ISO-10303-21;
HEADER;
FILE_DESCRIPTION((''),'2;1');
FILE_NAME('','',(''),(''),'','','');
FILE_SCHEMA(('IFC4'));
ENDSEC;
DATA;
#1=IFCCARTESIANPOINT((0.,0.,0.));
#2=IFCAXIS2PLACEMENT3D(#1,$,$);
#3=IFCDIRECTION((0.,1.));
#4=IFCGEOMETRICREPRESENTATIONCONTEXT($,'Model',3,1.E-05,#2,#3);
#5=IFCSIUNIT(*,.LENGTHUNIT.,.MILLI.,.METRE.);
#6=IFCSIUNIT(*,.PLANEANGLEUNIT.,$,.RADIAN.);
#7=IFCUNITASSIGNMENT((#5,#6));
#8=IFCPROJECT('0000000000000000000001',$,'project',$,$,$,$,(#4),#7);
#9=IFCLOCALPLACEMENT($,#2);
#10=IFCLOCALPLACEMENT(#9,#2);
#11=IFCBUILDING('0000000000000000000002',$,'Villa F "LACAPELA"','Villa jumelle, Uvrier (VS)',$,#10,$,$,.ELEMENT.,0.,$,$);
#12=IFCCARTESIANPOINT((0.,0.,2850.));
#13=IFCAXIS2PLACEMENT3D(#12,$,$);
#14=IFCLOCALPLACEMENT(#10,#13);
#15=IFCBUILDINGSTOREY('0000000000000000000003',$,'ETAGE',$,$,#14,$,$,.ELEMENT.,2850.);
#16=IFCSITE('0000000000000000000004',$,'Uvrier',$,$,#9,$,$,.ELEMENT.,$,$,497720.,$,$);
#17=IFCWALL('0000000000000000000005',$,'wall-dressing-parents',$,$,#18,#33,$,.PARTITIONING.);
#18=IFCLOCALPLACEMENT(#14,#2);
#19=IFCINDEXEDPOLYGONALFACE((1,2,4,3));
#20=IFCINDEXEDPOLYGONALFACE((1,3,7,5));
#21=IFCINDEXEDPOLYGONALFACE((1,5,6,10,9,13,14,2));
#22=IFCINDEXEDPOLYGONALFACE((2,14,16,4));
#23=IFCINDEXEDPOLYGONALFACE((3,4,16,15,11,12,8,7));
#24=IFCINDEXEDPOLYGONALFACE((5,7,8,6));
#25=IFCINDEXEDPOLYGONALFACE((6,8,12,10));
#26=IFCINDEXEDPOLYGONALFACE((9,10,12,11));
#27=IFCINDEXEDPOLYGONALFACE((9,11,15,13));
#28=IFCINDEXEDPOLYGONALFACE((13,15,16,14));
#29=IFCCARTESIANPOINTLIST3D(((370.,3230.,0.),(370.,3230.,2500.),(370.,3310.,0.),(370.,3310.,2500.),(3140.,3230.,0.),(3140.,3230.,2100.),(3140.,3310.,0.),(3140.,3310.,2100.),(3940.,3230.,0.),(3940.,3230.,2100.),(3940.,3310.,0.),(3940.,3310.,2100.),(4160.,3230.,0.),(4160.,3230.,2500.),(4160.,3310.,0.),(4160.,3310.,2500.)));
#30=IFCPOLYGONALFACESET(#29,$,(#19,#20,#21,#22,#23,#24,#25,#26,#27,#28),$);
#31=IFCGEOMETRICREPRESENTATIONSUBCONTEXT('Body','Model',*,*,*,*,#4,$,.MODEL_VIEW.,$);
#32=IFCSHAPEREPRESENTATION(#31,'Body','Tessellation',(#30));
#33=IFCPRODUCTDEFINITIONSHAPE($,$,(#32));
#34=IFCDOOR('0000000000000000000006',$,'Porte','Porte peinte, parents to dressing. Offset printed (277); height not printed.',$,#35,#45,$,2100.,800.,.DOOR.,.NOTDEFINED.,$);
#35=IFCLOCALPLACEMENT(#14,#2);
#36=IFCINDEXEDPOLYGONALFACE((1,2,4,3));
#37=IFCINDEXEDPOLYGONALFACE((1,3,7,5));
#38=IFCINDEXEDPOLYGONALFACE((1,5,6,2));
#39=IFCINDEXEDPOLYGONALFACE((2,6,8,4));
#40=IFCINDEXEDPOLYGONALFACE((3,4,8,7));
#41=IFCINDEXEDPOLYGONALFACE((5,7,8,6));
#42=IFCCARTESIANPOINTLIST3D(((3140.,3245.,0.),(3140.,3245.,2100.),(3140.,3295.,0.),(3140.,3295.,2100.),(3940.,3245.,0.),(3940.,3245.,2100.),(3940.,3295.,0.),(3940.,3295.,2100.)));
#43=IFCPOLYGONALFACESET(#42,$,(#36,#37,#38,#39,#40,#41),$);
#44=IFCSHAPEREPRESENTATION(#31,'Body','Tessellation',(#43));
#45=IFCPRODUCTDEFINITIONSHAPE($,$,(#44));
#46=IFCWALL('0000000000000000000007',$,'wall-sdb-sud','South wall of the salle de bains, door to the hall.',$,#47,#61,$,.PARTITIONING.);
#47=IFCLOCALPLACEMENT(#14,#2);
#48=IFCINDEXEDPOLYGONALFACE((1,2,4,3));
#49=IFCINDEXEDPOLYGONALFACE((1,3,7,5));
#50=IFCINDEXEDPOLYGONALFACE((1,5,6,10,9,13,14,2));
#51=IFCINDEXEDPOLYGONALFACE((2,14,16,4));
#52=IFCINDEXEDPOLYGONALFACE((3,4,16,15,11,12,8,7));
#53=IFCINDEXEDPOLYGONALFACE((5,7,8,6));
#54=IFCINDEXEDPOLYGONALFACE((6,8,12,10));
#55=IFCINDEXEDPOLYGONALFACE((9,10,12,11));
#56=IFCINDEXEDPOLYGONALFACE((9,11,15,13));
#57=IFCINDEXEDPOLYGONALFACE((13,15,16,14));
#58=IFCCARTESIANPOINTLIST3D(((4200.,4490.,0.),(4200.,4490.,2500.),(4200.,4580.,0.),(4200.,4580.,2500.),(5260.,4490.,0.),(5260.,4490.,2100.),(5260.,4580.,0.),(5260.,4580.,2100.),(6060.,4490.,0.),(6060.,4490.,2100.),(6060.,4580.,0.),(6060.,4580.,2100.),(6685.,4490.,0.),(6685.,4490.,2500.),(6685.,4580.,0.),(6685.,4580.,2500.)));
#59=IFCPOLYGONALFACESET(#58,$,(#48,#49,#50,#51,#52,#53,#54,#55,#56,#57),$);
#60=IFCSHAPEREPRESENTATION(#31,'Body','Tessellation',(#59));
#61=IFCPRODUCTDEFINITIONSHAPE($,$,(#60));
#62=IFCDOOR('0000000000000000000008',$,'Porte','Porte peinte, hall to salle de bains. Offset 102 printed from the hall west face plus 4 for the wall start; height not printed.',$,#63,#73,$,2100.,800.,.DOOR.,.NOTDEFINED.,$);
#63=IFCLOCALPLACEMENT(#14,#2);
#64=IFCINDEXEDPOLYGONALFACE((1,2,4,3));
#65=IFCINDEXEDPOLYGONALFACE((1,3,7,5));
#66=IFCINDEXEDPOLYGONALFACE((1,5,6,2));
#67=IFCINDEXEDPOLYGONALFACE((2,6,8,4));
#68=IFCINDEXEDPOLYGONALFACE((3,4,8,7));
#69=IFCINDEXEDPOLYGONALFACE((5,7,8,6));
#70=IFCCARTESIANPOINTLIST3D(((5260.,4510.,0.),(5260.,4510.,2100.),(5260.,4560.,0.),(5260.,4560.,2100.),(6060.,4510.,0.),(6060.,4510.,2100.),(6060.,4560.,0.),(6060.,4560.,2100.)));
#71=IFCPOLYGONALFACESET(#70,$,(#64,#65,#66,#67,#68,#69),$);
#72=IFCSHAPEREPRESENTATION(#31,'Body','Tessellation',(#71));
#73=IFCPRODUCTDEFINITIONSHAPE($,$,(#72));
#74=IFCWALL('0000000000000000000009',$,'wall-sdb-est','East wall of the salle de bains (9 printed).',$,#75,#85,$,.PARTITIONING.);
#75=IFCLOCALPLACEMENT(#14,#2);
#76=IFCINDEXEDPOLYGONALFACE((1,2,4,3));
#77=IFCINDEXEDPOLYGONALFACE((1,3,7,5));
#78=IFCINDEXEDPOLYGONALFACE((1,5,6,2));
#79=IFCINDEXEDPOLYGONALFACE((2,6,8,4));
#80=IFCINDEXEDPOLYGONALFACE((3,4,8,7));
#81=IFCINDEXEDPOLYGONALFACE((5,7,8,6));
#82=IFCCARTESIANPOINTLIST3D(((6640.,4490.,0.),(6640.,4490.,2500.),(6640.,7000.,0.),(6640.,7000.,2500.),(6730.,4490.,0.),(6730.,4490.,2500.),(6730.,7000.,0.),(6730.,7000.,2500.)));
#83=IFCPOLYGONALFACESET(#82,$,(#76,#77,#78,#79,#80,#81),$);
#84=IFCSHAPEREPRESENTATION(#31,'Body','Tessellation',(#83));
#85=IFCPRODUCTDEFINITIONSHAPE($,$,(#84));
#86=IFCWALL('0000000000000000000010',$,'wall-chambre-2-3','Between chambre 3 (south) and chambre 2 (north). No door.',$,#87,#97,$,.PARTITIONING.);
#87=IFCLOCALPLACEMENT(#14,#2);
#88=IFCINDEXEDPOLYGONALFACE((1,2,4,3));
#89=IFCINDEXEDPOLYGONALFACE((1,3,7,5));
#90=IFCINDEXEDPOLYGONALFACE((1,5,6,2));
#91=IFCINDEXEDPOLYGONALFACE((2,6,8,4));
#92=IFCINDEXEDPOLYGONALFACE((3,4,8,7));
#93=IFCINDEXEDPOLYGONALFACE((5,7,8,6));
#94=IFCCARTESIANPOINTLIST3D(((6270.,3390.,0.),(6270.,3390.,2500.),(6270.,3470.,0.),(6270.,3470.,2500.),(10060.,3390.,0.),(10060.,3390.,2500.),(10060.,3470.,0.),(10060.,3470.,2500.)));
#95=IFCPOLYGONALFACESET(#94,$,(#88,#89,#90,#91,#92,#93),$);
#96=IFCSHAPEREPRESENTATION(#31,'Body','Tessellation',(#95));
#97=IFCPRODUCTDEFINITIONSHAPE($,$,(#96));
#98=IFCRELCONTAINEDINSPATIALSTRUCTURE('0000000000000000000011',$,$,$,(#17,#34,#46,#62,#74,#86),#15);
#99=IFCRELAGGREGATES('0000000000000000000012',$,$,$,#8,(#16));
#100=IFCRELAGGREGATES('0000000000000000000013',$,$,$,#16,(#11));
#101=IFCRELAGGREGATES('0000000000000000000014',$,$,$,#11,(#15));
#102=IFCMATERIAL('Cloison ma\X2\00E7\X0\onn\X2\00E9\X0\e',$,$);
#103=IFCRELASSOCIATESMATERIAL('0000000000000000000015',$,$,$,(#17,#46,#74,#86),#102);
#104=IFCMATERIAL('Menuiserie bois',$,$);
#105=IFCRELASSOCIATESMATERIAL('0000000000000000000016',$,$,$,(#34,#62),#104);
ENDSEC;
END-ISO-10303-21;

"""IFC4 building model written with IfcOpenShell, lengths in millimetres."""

from ifc_helpers import new_model, si_unit, direction, frame, frame_2d, origin, place, context, subcontext, project, spatial, rectangle, extrude, material, element, fill, save


model = new_model("IFC4")

# Units and contexts
model_context = context("Model", 3, precision=1e-05, world=origin(), true_north=direction((0.0, 1.0)))
body_context = subcontext(model_context, "Body", "Model", "MODEL_VIEW")
ifc_project = project(units=[si_unit("LENGTHUNIT", "METRE", prefix="MILLI"), si_unit("PLANEANGLEUNIT", "RADIAN")], contexts=[model_context])

# Site, building, storey
site_placement = place(None, origin())
site = spatial("IfcSite", under=ifc_project, at=site_placement, Name="Uvrier", CompositionType="ELEMENT", RefElevation=497720.0)
building_placement = place(site_placement, origin())
building = spatial("IfcBuilding", under=site, at=building_placement, Name="Villa F \"LACAPELA\"", Description="Villa jumelle, Uvrier (VS)", CompositionType="ELEMENT", ElevationOfRefHeight=0.0)
storey_placement = place(building_placement, frame((0.0, 0.0, 2850.0)))
storey = spatial("IfcBuildingStorey", under=building, at=storey_placement, Name="ETAGE", CompositionType="ELEMENT", Elevation=2850.0)

# Shared definitions
ifc_material_1 = material(Name="Cloison maçonnée")
ifc_material_2 = material(Name="Menuiserie bois")

# Walls, openings, doors
wall_1_placement = place(storey_placement, frame((370.0, 3270.0, 0.0), z_axis=(0.0, 0.0, 1.0), x_axis=(1.0, 0.0, 0.0)))
wall_1 = element("IfcWall", 1, at=wall_1_placement, inside=storey, material=ifc_material_1, Name="wall-dressing-parents", PredefinedType="PARTITIONING", context=body_context, shape_type="SweptSolid", body=[
    extrude(rectangle(XDim=3790.0, YDim=80.0, at=frame_2d((1895.0, 0.0))), origin(), (0.0, 0.0, 1.0), 2500.0),
])
opening_1_placement = place(wall_1_placement, frame((2770.0, 0.0, 0.0)))
opening_1 = element("IfcOpeningElement", 2, at=opening_1_placement, cuts=wall_1, PredefinedType="OPENING", context=body_context, shape_type="SweptSolid", body=[
    extrude(rectangle(XDim=800.0, YDim=280.0, at=frame_2d((400.0, 0.0))), origin(), (0.0, 0.0, 1.0), 2100.0),
])
door_1_placement = place(opening_1_placement, origin())
door_1 = element("IfcDoor", 3, at=door_1_placement, inside=storey, material=ifc_material_2, Name="Porte", Description="Porte peinte, parents to dressing. Offset printed (277); height not printed.", OperationType="NOTDEFINED", OverallHeight=2100.0, OverallWidth=800.0, PredefinedType="DOOR", context=body_context, shape_type="SweptSolid", body=[
    extrude(rectangle(XDim=800.0, YDim=50.0, at=frame_2d((400.0, 0.0))), origin(), (0.0, 0.0, 1.0), 2100.0),
])
fill(opening_1, door_1)
wall_2_placement = place(storey_placement, frame((4200.0, 4535.0, 0.0), z_axis=(0.0, 0.0, 1.0), x_axis=(1.0, 0.0, 0.0)))
wall_2 = element("IfcWall", 4, at=wall_2_placement, inside=storey, material=ifc_material_1, Name="wall-sdb-sud", Description="South wall of the salle de bains, door to the hall.", PredefinedType="PARTITIONING", context=body_context, shape_type="SweptSolid", body=[
    extrude(rectangle(XDim=2485.0, YDim=90.0, at=frame_2d((1242.5, 0.0))), origin(), (0.0, 0.0, 1.0), 2500.0),
])
opening_2_placement = place(wall_2_placement, frame((1060.0, 0.0, 0.0)))
opening_2 = element("IfcOpeningElement", 5, at=opening_2_placement, cuts=wall_2, PredefinedType="OPENING", context=body_context, shape_type="SweptSolid", body=[
    extrude(rectangle(XDim=800.0, YDim=290.0, at=frame_2d((400.0, 0.0))), origin(), (0.0, 0.0, 1.0), 2100.0),
])
door_2_placement = place(opening_2_placement, origin())
door_2 = element("IfcDoor", 6, at=door_2_placement, inside=storey, material=ifc_material_2, Name="Porte", Description="Porte peinte, hall to salle de bains. Offset 102 printed from the hall west face plus 4 for the wall start; height not printed.", OperationType="NOTDEFINED", OverallHeight=2100.0, OverallWidth=800.0, PredefinedType="DOOR", context=body_context, shape_type="SweptSolid", body=[
    extrude(rectangle(XDim=800.0, YDim=50.0, at=frame_2d((400.0, 0.0))), origin(), (0.0, 0.0, 1.0), 2100.0),
])
fill(opening_2, door_2)

# Walls
wall_3_placement = place(storey_placement, frame((6685.0, 4490.0, 0.0), z_axis=(0.0, 0.0, 1.0), x_axis=(0.0, 1.0, 0.0)))
element("IfcWall", 7, at=wall_3_placement, inside=storey, material=ifc_material_1, Name="wall-sdb-est", Description="East wall of the salle de bains (9 printed).", PredefinedType="PARTITIONING", context=body_context, shape_type="SweptSolid", body=[
    extrude(rectangle(XDim=2510.0, YDim=90.0, at=frame_2d((1255.0, 0.0))), origin(), (0.0, 0.0, 1.0), 2500.0),
])
wall_4_placement = place(storey_placement, frame((6270.0, 3430.0, 0.0), z_axis=(0.0, 0.0, 1.0), x_axis=(1.0, 0.0, 0.0)))
element("IfcWall", 8, at=wall_4_placement, inside=storey, material=ifc_material_1, Name="wall-chambre-2-3", Description="Between chambre 3 (south) and chambre 2 (north). No door.", PredefinedType="PARTITIONING", context=body_context, shape_type="SweptSolid", body=[
    extrude(rectangle(XDim=3790.0, YDim=80.0, at=frame_2d((1895.0, 0.0))), origin(), (0.0, 0.0, 1.0), 2500.0),
])

save(model, "model.ifc")
